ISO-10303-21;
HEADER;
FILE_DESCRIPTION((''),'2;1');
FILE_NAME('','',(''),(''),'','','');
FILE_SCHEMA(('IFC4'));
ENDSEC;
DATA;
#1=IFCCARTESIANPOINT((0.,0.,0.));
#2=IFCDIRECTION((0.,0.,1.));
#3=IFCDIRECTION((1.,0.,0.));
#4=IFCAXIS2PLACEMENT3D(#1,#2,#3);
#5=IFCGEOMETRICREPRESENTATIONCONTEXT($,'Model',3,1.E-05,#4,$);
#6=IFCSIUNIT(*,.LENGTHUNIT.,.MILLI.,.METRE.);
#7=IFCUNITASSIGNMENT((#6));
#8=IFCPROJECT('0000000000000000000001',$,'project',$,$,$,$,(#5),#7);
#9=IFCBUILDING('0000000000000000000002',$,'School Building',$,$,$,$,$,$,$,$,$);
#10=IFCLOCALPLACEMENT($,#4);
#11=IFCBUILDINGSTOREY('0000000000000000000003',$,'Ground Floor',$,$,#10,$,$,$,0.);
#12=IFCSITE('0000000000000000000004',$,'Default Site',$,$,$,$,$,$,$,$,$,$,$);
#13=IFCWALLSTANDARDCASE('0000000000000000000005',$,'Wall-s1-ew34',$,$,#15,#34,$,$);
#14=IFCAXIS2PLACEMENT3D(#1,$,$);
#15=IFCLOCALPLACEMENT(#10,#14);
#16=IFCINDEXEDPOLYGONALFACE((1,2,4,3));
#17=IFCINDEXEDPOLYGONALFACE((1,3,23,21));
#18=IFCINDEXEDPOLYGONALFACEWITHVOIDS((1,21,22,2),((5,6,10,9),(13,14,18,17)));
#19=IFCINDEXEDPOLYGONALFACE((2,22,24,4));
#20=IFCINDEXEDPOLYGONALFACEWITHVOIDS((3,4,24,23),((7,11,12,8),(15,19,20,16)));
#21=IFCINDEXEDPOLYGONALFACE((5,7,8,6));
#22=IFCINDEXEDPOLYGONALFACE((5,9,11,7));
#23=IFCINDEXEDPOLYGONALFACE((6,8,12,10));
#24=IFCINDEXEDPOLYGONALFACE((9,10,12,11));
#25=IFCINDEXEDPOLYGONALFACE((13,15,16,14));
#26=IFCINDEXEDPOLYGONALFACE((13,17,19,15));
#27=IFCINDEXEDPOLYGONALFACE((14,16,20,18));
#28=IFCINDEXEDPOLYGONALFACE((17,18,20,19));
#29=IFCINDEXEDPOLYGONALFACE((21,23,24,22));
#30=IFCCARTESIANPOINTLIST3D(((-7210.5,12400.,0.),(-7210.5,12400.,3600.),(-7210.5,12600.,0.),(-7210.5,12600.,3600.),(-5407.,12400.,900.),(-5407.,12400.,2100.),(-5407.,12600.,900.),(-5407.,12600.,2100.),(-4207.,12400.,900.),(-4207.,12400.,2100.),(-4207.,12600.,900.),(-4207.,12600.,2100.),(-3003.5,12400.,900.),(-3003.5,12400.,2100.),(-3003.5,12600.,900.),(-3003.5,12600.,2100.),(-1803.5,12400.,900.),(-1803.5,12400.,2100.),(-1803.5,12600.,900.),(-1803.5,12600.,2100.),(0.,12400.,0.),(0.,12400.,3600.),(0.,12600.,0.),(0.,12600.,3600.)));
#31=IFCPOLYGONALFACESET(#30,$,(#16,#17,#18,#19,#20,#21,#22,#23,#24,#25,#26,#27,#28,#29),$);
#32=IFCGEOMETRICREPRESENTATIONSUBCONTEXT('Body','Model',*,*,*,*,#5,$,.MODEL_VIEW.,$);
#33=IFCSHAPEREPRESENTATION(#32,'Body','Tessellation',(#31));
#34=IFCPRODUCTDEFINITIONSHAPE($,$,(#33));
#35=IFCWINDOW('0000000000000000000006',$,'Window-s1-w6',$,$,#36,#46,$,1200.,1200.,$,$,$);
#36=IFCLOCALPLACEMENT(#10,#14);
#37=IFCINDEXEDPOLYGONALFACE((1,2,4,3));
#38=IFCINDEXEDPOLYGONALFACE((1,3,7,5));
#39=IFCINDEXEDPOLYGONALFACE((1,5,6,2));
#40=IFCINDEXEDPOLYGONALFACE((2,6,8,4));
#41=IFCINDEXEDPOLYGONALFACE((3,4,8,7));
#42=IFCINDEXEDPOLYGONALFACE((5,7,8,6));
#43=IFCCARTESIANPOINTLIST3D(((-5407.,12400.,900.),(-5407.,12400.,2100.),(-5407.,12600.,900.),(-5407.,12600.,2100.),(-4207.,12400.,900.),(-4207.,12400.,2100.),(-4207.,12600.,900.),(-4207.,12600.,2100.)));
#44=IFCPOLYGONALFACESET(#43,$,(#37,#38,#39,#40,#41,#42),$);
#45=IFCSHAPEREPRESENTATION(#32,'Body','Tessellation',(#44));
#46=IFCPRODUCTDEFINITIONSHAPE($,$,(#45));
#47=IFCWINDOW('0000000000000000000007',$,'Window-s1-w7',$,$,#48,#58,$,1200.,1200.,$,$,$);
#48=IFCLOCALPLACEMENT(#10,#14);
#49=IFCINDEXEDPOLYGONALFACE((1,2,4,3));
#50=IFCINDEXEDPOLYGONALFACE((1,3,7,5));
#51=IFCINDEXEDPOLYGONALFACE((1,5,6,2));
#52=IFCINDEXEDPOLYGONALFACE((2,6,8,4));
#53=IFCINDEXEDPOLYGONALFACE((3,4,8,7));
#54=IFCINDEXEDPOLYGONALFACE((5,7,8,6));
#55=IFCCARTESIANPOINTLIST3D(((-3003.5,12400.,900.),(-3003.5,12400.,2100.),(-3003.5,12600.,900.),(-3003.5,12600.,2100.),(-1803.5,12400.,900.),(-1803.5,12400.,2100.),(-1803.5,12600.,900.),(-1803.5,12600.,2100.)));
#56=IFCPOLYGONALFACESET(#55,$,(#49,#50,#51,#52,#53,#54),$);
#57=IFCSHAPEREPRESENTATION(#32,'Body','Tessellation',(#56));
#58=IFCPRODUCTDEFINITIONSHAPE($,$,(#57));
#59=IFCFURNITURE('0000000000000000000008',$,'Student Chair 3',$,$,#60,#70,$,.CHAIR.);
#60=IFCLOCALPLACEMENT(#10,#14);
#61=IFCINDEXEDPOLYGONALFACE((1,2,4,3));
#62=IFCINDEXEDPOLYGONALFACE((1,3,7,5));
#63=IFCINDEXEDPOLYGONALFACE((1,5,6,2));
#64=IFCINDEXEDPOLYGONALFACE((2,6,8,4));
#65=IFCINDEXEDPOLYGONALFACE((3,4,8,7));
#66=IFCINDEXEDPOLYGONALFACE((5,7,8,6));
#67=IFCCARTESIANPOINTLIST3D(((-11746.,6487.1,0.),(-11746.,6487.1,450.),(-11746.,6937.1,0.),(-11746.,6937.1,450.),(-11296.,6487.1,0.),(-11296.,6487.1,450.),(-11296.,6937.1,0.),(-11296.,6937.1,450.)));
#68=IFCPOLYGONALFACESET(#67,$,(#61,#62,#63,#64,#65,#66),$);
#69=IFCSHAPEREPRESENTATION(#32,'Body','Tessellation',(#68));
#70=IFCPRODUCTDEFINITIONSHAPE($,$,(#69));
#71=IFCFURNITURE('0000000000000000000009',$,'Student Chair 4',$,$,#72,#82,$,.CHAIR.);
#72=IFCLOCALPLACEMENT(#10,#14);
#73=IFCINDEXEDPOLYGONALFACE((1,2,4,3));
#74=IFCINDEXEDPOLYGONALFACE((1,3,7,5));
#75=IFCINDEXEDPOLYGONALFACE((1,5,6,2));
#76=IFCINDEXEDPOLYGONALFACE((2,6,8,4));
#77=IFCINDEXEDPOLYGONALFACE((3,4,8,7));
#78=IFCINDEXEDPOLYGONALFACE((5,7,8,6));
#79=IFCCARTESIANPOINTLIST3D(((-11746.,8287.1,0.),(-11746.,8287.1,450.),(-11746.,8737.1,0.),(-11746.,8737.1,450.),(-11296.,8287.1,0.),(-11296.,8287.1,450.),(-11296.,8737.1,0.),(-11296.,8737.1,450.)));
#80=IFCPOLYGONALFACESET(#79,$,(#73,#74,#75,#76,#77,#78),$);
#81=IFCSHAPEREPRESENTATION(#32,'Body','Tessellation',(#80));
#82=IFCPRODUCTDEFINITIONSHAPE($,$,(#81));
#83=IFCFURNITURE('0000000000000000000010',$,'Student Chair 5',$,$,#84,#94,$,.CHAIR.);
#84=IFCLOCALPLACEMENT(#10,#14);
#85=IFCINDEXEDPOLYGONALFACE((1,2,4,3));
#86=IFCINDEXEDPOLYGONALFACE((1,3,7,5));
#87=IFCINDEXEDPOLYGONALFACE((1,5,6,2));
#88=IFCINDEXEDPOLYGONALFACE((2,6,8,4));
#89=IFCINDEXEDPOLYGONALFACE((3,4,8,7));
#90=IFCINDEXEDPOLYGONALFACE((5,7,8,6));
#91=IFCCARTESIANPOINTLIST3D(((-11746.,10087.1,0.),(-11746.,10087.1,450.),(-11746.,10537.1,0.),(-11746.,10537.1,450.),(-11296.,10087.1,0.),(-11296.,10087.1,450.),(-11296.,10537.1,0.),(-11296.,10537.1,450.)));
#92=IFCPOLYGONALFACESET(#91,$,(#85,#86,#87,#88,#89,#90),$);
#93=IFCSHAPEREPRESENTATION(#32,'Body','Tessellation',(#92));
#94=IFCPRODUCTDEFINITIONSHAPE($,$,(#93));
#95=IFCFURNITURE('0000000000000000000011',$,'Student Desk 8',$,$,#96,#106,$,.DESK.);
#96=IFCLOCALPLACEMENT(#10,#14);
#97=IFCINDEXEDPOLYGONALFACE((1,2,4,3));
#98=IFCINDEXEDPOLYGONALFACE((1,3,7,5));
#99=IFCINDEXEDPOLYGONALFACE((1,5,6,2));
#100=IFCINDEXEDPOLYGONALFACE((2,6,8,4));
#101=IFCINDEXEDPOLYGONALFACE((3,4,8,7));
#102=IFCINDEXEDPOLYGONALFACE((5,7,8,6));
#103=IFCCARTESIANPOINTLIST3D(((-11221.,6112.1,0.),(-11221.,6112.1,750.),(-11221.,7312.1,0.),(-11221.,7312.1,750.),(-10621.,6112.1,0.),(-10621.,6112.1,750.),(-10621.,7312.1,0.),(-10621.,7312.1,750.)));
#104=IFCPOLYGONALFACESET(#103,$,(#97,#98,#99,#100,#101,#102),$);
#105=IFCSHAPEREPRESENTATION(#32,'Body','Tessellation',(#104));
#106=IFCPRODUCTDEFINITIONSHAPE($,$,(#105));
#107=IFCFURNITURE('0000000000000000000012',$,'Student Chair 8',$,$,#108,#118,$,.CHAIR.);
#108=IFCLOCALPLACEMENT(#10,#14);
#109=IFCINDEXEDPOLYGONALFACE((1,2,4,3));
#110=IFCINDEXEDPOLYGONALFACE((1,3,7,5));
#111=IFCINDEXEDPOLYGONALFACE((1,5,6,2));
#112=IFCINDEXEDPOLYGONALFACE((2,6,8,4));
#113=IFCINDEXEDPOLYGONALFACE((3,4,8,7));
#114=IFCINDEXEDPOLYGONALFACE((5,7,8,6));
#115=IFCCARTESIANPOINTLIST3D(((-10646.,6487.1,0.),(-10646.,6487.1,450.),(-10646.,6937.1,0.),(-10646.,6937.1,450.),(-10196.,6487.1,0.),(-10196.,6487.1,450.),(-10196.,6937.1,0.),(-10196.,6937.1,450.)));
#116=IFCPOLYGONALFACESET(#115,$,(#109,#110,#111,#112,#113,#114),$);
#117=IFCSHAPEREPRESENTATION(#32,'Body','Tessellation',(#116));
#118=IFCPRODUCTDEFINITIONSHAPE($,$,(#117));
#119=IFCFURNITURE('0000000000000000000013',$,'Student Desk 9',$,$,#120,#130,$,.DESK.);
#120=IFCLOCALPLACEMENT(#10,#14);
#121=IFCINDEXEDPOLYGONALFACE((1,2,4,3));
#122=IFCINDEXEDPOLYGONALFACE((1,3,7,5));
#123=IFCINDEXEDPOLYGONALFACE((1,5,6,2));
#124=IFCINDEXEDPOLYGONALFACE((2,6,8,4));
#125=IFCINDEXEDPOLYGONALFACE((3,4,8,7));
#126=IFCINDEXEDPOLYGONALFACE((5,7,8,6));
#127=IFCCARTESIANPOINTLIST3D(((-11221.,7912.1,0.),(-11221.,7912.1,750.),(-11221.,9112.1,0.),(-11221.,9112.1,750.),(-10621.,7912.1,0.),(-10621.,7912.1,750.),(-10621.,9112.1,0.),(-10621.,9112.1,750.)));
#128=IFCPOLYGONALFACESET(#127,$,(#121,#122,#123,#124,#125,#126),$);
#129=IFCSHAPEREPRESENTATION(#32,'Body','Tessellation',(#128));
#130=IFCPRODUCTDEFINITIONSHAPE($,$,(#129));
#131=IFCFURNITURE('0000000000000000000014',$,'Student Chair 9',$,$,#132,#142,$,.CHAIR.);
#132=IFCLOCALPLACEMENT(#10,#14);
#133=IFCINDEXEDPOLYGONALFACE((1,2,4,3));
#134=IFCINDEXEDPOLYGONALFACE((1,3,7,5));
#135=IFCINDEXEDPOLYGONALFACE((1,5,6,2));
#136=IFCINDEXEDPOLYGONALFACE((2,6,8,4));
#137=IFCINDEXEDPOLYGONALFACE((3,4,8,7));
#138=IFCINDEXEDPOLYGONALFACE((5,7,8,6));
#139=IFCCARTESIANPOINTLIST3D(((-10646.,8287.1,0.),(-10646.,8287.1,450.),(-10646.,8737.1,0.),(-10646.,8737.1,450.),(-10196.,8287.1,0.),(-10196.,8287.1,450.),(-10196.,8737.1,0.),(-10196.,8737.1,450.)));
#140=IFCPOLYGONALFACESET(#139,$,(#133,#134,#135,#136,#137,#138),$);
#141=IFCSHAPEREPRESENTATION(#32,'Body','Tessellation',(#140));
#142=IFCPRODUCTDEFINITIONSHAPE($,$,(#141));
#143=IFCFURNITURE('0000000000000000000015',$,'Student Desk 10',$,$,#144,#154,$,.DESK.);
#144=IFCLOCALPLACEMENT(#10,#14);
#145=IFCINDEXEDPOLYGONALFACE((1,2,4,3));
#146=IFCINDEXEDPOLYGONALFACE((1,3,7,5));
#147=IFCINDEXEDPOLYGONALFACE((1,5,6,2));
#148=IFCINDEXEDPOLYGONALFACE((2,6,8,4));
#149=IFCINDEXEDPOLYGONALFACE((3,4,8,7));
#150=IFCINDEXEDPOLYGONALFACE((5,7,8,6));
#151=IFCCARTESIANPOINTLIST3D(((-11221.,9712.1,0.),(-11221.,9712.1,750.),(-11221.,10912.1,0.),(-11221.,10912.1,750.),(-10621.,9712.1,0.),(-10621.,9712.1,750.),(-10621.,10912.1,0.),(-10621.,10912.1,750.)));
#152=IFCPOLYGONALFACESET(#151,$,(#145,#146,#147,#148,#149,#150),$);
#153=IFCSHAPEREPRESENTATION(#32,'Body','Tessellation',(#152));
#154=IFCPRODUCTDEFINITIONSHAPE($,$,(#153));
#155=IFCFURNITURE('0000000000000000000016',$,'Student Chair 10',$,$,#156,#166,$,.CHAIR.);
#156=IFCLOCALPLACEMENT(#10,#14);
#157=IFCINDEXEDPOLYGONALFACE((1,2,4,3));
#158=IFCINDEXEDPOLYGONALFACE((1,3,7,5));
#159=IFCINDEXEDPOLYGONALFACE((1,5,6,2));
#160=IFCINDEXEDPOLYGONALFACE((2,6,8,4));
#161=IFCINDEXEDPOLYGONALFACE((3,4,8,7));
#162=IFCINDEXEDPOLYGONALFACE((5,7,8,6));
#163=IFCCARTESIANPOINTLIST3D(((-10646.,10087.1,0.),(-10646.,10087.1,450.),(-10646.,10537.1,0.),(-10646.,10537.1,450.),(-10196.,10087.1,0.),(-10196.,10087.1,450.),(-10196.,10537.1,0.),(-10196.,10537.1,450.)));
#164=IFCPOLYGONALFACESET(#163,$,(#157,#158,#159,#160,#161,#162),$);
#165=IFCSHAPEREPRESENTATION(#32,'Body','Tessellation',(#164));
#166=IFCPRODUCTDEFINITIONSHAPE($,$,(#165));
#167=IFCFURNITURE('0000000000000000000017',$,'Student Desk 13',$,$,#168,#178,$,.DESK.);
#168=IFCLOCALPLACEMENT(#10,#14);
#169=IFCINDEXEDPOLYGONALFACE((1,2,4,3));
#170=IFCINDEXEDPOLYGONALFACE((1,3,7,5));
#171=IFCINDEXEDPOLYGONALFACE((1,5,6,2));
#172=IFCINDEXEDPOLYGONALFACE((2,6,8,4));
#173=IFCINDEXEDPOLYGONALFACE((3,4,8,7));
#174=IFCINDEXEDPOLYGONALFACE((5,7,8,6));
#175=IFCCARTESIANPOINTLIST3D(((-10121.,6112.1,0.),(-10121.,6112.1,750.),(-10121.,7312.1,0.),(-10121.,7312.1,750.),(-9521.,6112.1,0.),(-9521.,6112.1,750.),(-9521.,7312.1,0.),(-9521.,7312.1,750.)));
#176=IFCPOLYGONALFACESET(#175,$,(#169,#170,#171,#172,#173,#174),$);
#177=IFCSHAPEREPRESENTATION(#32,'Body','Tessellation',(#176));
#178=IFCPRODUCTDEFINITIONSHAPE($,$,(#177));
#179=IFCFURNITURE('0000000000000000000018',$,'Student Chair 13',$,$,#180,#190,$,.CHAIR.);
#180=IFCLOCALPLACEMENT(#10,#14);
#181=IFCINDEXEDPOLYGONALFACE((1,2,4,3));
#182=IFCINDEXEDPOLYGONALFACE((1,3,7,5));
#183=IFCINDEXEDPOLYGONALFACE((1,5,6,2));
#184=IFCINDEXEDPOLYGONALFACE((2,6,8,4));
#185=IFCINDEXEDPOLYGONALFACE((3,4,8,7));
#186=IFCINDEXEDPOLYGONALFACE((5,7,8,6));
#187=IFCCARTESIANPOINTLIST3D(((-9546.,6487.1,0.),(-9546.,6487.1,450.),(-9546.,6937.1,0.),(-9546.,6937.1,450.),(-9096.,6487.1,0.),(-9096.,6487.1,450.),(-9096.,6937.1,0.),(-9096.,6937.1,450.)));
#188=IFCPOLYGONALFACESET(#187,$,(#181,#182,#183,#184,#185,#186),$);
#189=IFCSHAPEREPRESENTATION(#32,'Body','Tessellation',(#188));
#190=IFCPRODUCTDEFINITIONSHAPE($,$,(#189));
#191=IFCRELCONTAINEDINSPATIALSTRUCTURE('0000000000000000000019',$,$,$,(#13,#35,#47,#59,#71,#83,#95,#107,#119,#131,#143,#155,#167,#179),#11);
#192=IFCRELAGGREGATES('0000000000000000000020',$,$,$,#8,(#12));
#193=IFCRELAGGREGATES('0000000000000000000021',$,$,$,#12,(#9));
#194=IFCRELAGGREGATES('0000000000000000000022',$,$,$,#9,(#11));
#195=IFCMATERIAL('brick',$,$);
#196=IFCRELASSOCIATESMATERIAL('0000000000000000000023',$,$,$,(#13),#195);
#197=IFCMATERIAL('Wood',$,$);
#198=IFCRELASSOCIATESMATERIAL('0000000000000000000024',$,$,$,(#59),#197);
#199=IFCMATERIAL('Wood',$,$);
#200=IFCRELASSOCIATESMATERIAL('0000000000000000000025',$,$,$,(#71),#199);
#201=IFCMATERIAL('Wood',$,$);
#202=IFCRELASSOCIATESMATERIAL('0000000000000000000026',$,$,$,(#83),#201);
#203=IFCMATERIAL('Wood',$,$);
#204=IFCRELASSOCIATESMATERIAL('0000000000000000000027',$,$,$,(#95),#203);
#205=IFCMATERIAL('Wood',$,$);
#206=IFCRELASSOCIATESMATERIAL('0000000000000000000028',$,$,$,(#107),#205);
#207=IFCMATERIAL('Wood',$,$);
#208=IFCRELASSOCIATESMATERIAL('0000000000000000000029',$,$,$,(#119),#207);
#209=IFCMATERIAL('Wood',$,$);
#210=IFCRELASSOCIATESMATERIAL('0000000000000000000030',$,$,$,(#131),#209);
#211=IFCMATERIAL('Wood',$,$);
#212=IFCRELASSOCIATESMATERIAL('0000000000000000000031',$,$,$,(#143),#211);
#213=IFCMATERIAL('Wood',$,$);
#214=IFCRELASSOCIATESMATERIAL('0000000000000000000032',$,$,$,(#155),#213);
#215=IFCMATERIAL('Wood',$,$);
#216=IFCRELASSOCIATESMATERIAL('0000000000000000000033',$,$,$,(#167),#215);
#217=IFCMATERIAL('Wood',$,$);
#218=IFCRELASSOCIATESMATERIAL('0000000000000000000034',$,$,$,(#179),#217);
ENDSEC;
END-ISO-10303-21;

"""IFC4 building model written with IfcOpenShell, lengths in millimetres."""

from ifc_helpers import new_model, si_unit, frame, frame_2d, origin_with_axes, origin_2d, place, context, subcontext, project, spatial, rectangle, extrude, material, element, fill, save


model = new_model("IFC4")

# Units and contexts
model_context = context("Model", 3, precision=1e-05, world=origin_with_axes())
body_context = subcontext(model_context, "Body", "Model", "MODEL_VIEW")
ifc_project = project(units=[si_unit("LENGTHUNIT", "METRE", prefix="MILLI")], contexts=[model_context])

# Site, building, storey
site = spatial("IfcSite", under=ifc_project, Name="Default Site")
building = spatial("IfcBuilding", under=site, Name="School Building")
storey_placement = place(None, origin_with_axes())
storey = spatial("IfcBuildingStorey", under=building, at=storey_placement, Name="Ground Floor", Elevation=0.0)

# Wall, openings, windows
ifc_material_1 = material(Name="brick")
wall_placement = place(storey_placement, frame((-7210.5, 12500.0, 0.0), z_axis=(0.0, 0.0, 1.0), x_axis=(1.0, 0.0, 0.0)))
wall = element("IfcWallStandardCase", 1, at=wall_placement, inside=storey, material=ifc_material_1, Name="Wall-s1-ew34", context=body_context, shape_type="SweptSolid", body=[
    extrude(rectangle(XDim=7210.5, YDim=200.0, at=frame_2d((3605.2, 0.0))), origin_with_axes(), (0.0, 0.0, 1.0), 3600.0),
])
opening_1_placement = place(wall_placement, frame((1803.5, 0.0, 900.0), z_axis=(0.0, 0.0, 1.0), x_axis=(1.0, 0.0, 0.0)))
opening_1 = element("IfcOpeningElement", 2, at=opening_1_placement, cuts=wall, context=body_context, shape_type="SweptSolid", body=[
    extrude(rectangle(XDim=1200.0, YDim=400.0, at=frame_2d((600.0, 0.0))), origin_with_axes(), (0.0, 0.0, 1.0), 1200.0),
])
opening_2_placement = place(wall_placement, frame((4207.0, 0.0, 900.0), z_axis=(0.0, 0.0, 1.0), x_axis=(1.0, 0.0, 0.0)))
opening_2 = element("IfcOpeningElement", 3, at=opening_2_placement, cuts=wall, context=body_context, shape_type="SweptSolid", body=[
    extrude(rectangle(XDim=1200.0, YDim=400.0, at=frame_2d((600.0, 0.0))), origin_with_axes(), (0.0, 0.0, 1.0), 1200.0),
])
window_1_placement = place(storey_placement, frame((-5407.0, 12500.0, 900.0), z_axis=(0.0, 0.0, 1.0), x_axis=(1.0, 0.0, 0.0)))
window_1 = element("IfcWindow", 4, at=window_1_placement, inside=storey, Name="Window-s1-w6", OverallHeight=1200.0, OverallWidth=1200.0, context=body_context, shape_type="SweptSolid", body=[
    extrude(rectangle(XDim=1200.0, YDim=200.0, at=frame_2d((600.0, 0.0))), origin_with_axes(), (0.0, 0.0, 1.0), 1200.0),
])
fill(opening_1, window_1)
window_2_placement = place(storey_placement, frame((-3003.5, 12500.0, 900.0), z_axis=(0.0, 0.0, 1.0), x_axis=(1.0, 0.0, 0.0)))
window_2 = element("IfcWindow", 5, at=window_2_placement, inside=storey, Name="Window-s1-w7", OverallHeight=1200.0, OverallWidth=1200.0, context=body_context, shape_type="SweptSolid", body=[
    extrude(rectangle(XDim=1200.0, YDim=200.0, at=frame_2d((600.0, 0.0))), origin_with_axes(), (0.0, 0.0, 1.0), 1200.0),
])
fill(opening_2, window_2)

# Furniture
ifc_material_2 = material(Name="Wood")
furniture_1_placement = place(storey_placement, frame((-11521.0, 6712.1, 0.0), z_axis=(0.0, 0.0, 1.0), x_axis=(1.0, 0.0, 0.0)))
element("IfcFurniture", 6, at=furniture_1_placement, inside=storey, material=ifc_material_2, Name="Student Chair 3", PredefinedType="CHAIR", context=body_context, shape_type="SweptSolid", body=[
    extrude(rectangle(XDim=450.0, YDim=450.0, at=origin_2d()), origin_with_axes(), (0.0, 0.0, 1.0), 450.0),
])
ifc_material_3 = material(Name="Wood")
furniture_2_placement = place(storey_placement, frame((-11521.0, 8512.1, 0.0), z_axis=(0.0, 0.0, 1.0), x_axis=(1.0, 0.0, 0.0)))
element("IfcFurniture", 7, at=furniture_2_placement, inside=storey, material=ifc_material_3, Name="Student Chair 4", PredefinedType="CHAIR", context=body_context, shape_type="SweptSolid", body=[
    extrude(rectangle(XDim=450.0, YDim=450.0, at=origin_2d()), origin_with_axes(), (0.0, 0.0, 1.0), 450.0),
])
ifc_material_4 = material(Name="Wood")
furniture_3_placement = place(storey_placement, frame((-11521.0, 10312.1, 0.0), z_axis=(0.0, 0.0, 1.0), x_axis=(1.0, 0.0, 0.0)))
element("IfcFurniture", 8, at=furniture_3_placement, inside=storey, material=ifc_material_4, Name="Student Chair 5", PredefinedType="CHAIR", context=body_context, shape_type="SweptSolid", body=[
    extrude(rectangle(XDim=450.0, YDim=450.0, at=origin_2d()), origin_with_axes(), (0.0, 0.0, 1.0), 450.0),
])
ifc_material_5 = material(Name="Wood")
furniture_4_placement = place(storey_placement, frame((-10921.0, 6712.1, 0.0), z_axis=(0.0, 0.0, 1.0), x_axis=(0.0, 1.0, 0.0)))
element("IfcFurniture", 9, at=furniture_4_placement, inside=storey, material=ifc_material_5, Name="Student Desk 8", PredefinedType="DESK", context=body_context, shape_type="SweptSolid", body=[
    extrude(rectangle(XDim=1200.0, YDim=600.0, at=origin_2d()), origin_with_axes(), (0.0, 0.0, 1.0), 750.0),
])
ifc_material_6 = material(Name="Wood")
furniture_5_placement = place(storey_placement, frame((-10421.0, 6712.1, 0.0), z_axis=(0.0, 0.0, 1.0), x_axis=(1.0, 0.0, 0.0)))
element("IfcFurniture", 10, at=furniture_5_placement, inside=storey, material=ifc_material_6, Name="Student Chair 8", PredefinedType="CHAIR", context=body_context, shape_type="SweptSolid", body=[
    extrude(rectangle(XDim=450.0, YDim=450.0, at=origin_2d()), origin_with_axes(), (0.0, 0.0, 1.0), 450.0),
])
ifc_material_7 = material(Name="Wood")
furniture_6_placement = place(storey_placement, frame((-10921.0, 8512.1, 0.0), z_axis=(0.0, 0.0, 1.0), x_axis=(0.0, 1.0, 0.0)))
element("IfcFurniture", 11, at=furniture_6_placement, inside=storey, material=ifc_material_7, Name="Student Desk 9", PredefinedType="DESK", context=body_context, shape_type="SweptSolid", body=[
    extrude(rectangle(XDim=1200.0, YDim=600.0, at=origin_2d()), origin_with_axes(), (0.0, 0.0, 1.0), 750.0),
])
ifc_material_8 = material(Name="Wood")
furniture_7_placement = place(storey_placement, frame((-10421.0, 8512.1, 0.0), z_axis=(0.0, 0.0, 1.0), x_axis=(1.0, 0.0, 0.0)))
element("IfcFurniture", 12, at=furniture_7_placement, inside=storey, material=ifc_material_8, Name="Student Chair 9", PredefinedType="CHAIR", context=body_context, shape_type="SweptSolid", body=[
    extrude(rectangle(XDim=450.0, YDim=450.0, at=origin_2d()), origin_with_axes(), (0.0, 0.0, 1.0), 450.0),
])
ifc_material_9 = material(Name="Wood")
furniture_8_placement = place(storey_placement, frame((-10921.0, 10312.1, 0.0), z_axis=(0.0, 0.0, 1.0), x_axis=(0.0, 1.0, 0.0)))
element("IfcFurniture", 13, at=furniture_8_placement, inside=storey, material=ifc_material_9, Name="Student Desk 10", PredefinedType="DESK", context=body_context, shape_type="SweptSolid", body=[
    extrude(rectangle(XDim=1200.0, YDim=600.0, at=origin_2d()), origin_with_axes(), (0.0, 0.0, 1.0), 750.0),
])
ifc_material_10 = material(Name="Wood")
furniture_9_placement = place(storey_placement, frame((-10421.0, 10312.1, 0.0), z_axis=(0.0, 0.0, 1.0), x_axis=(1.0, 0.0, 0.0)))
element("IfcFurniture", 14, at=furniture_9_placement, inside=storey, material=ifc_material_10, Name="Student Chair 10", PredefinedType="CHAIR", context=body_context, shape_type="SweptSolid", body=[
    extrude(rectangle(XDim=450.0, YDim=450.0, at=origin_2d()), origin_with_axes(), (0.0, 0.0, 1.0), 450.0),
])
ifc_material_11 = material(Name="Wood")
furniture_10_placement = place(storey_placement, frame((-9821.0, 6712.1, 0.0), z_axis=(0.0, 0.0, 1.0), x_axis=(0.0, 1.0, 0.0)))
element("IfcFurniture", 15, at=furniture_10_placement, inside=storey, material=ifc_material_11, Name="Student Desk 13", PredefinedType="DESK", context=body_context, shape_type="SweptSolid", body=[
    extrude(rectangle(XDim=1200.0, YDim=600.0, at=origin_2d()), origin_with_axes(), (0.0, 0.0, 1.0), 750.0),
])
ifc_material_12 = material(Name="Wood")
furniture_11_placement = place(storey_placement, frame((-9321.0, 6712.1, 0.0), z_axis=(0.0, 0.0, 1.0), x_axis=(1.0, 0.0, 0.0)))
element("IfcFurniture", 16, at=furniture_11_placement, inside=storey, material=ifc_material_12, Name="Student Chair 13", PredefinedType="CHAIR", context=body_context, shape_type="SweptSolid", body=[
    extrude(rectangle(XDim=450.0, YDim=450.0, at=origin_2d()), origin_with_axes(), (0.0, 0.0, 1.0), 450.0),
])

save(model, "model.ifc")
